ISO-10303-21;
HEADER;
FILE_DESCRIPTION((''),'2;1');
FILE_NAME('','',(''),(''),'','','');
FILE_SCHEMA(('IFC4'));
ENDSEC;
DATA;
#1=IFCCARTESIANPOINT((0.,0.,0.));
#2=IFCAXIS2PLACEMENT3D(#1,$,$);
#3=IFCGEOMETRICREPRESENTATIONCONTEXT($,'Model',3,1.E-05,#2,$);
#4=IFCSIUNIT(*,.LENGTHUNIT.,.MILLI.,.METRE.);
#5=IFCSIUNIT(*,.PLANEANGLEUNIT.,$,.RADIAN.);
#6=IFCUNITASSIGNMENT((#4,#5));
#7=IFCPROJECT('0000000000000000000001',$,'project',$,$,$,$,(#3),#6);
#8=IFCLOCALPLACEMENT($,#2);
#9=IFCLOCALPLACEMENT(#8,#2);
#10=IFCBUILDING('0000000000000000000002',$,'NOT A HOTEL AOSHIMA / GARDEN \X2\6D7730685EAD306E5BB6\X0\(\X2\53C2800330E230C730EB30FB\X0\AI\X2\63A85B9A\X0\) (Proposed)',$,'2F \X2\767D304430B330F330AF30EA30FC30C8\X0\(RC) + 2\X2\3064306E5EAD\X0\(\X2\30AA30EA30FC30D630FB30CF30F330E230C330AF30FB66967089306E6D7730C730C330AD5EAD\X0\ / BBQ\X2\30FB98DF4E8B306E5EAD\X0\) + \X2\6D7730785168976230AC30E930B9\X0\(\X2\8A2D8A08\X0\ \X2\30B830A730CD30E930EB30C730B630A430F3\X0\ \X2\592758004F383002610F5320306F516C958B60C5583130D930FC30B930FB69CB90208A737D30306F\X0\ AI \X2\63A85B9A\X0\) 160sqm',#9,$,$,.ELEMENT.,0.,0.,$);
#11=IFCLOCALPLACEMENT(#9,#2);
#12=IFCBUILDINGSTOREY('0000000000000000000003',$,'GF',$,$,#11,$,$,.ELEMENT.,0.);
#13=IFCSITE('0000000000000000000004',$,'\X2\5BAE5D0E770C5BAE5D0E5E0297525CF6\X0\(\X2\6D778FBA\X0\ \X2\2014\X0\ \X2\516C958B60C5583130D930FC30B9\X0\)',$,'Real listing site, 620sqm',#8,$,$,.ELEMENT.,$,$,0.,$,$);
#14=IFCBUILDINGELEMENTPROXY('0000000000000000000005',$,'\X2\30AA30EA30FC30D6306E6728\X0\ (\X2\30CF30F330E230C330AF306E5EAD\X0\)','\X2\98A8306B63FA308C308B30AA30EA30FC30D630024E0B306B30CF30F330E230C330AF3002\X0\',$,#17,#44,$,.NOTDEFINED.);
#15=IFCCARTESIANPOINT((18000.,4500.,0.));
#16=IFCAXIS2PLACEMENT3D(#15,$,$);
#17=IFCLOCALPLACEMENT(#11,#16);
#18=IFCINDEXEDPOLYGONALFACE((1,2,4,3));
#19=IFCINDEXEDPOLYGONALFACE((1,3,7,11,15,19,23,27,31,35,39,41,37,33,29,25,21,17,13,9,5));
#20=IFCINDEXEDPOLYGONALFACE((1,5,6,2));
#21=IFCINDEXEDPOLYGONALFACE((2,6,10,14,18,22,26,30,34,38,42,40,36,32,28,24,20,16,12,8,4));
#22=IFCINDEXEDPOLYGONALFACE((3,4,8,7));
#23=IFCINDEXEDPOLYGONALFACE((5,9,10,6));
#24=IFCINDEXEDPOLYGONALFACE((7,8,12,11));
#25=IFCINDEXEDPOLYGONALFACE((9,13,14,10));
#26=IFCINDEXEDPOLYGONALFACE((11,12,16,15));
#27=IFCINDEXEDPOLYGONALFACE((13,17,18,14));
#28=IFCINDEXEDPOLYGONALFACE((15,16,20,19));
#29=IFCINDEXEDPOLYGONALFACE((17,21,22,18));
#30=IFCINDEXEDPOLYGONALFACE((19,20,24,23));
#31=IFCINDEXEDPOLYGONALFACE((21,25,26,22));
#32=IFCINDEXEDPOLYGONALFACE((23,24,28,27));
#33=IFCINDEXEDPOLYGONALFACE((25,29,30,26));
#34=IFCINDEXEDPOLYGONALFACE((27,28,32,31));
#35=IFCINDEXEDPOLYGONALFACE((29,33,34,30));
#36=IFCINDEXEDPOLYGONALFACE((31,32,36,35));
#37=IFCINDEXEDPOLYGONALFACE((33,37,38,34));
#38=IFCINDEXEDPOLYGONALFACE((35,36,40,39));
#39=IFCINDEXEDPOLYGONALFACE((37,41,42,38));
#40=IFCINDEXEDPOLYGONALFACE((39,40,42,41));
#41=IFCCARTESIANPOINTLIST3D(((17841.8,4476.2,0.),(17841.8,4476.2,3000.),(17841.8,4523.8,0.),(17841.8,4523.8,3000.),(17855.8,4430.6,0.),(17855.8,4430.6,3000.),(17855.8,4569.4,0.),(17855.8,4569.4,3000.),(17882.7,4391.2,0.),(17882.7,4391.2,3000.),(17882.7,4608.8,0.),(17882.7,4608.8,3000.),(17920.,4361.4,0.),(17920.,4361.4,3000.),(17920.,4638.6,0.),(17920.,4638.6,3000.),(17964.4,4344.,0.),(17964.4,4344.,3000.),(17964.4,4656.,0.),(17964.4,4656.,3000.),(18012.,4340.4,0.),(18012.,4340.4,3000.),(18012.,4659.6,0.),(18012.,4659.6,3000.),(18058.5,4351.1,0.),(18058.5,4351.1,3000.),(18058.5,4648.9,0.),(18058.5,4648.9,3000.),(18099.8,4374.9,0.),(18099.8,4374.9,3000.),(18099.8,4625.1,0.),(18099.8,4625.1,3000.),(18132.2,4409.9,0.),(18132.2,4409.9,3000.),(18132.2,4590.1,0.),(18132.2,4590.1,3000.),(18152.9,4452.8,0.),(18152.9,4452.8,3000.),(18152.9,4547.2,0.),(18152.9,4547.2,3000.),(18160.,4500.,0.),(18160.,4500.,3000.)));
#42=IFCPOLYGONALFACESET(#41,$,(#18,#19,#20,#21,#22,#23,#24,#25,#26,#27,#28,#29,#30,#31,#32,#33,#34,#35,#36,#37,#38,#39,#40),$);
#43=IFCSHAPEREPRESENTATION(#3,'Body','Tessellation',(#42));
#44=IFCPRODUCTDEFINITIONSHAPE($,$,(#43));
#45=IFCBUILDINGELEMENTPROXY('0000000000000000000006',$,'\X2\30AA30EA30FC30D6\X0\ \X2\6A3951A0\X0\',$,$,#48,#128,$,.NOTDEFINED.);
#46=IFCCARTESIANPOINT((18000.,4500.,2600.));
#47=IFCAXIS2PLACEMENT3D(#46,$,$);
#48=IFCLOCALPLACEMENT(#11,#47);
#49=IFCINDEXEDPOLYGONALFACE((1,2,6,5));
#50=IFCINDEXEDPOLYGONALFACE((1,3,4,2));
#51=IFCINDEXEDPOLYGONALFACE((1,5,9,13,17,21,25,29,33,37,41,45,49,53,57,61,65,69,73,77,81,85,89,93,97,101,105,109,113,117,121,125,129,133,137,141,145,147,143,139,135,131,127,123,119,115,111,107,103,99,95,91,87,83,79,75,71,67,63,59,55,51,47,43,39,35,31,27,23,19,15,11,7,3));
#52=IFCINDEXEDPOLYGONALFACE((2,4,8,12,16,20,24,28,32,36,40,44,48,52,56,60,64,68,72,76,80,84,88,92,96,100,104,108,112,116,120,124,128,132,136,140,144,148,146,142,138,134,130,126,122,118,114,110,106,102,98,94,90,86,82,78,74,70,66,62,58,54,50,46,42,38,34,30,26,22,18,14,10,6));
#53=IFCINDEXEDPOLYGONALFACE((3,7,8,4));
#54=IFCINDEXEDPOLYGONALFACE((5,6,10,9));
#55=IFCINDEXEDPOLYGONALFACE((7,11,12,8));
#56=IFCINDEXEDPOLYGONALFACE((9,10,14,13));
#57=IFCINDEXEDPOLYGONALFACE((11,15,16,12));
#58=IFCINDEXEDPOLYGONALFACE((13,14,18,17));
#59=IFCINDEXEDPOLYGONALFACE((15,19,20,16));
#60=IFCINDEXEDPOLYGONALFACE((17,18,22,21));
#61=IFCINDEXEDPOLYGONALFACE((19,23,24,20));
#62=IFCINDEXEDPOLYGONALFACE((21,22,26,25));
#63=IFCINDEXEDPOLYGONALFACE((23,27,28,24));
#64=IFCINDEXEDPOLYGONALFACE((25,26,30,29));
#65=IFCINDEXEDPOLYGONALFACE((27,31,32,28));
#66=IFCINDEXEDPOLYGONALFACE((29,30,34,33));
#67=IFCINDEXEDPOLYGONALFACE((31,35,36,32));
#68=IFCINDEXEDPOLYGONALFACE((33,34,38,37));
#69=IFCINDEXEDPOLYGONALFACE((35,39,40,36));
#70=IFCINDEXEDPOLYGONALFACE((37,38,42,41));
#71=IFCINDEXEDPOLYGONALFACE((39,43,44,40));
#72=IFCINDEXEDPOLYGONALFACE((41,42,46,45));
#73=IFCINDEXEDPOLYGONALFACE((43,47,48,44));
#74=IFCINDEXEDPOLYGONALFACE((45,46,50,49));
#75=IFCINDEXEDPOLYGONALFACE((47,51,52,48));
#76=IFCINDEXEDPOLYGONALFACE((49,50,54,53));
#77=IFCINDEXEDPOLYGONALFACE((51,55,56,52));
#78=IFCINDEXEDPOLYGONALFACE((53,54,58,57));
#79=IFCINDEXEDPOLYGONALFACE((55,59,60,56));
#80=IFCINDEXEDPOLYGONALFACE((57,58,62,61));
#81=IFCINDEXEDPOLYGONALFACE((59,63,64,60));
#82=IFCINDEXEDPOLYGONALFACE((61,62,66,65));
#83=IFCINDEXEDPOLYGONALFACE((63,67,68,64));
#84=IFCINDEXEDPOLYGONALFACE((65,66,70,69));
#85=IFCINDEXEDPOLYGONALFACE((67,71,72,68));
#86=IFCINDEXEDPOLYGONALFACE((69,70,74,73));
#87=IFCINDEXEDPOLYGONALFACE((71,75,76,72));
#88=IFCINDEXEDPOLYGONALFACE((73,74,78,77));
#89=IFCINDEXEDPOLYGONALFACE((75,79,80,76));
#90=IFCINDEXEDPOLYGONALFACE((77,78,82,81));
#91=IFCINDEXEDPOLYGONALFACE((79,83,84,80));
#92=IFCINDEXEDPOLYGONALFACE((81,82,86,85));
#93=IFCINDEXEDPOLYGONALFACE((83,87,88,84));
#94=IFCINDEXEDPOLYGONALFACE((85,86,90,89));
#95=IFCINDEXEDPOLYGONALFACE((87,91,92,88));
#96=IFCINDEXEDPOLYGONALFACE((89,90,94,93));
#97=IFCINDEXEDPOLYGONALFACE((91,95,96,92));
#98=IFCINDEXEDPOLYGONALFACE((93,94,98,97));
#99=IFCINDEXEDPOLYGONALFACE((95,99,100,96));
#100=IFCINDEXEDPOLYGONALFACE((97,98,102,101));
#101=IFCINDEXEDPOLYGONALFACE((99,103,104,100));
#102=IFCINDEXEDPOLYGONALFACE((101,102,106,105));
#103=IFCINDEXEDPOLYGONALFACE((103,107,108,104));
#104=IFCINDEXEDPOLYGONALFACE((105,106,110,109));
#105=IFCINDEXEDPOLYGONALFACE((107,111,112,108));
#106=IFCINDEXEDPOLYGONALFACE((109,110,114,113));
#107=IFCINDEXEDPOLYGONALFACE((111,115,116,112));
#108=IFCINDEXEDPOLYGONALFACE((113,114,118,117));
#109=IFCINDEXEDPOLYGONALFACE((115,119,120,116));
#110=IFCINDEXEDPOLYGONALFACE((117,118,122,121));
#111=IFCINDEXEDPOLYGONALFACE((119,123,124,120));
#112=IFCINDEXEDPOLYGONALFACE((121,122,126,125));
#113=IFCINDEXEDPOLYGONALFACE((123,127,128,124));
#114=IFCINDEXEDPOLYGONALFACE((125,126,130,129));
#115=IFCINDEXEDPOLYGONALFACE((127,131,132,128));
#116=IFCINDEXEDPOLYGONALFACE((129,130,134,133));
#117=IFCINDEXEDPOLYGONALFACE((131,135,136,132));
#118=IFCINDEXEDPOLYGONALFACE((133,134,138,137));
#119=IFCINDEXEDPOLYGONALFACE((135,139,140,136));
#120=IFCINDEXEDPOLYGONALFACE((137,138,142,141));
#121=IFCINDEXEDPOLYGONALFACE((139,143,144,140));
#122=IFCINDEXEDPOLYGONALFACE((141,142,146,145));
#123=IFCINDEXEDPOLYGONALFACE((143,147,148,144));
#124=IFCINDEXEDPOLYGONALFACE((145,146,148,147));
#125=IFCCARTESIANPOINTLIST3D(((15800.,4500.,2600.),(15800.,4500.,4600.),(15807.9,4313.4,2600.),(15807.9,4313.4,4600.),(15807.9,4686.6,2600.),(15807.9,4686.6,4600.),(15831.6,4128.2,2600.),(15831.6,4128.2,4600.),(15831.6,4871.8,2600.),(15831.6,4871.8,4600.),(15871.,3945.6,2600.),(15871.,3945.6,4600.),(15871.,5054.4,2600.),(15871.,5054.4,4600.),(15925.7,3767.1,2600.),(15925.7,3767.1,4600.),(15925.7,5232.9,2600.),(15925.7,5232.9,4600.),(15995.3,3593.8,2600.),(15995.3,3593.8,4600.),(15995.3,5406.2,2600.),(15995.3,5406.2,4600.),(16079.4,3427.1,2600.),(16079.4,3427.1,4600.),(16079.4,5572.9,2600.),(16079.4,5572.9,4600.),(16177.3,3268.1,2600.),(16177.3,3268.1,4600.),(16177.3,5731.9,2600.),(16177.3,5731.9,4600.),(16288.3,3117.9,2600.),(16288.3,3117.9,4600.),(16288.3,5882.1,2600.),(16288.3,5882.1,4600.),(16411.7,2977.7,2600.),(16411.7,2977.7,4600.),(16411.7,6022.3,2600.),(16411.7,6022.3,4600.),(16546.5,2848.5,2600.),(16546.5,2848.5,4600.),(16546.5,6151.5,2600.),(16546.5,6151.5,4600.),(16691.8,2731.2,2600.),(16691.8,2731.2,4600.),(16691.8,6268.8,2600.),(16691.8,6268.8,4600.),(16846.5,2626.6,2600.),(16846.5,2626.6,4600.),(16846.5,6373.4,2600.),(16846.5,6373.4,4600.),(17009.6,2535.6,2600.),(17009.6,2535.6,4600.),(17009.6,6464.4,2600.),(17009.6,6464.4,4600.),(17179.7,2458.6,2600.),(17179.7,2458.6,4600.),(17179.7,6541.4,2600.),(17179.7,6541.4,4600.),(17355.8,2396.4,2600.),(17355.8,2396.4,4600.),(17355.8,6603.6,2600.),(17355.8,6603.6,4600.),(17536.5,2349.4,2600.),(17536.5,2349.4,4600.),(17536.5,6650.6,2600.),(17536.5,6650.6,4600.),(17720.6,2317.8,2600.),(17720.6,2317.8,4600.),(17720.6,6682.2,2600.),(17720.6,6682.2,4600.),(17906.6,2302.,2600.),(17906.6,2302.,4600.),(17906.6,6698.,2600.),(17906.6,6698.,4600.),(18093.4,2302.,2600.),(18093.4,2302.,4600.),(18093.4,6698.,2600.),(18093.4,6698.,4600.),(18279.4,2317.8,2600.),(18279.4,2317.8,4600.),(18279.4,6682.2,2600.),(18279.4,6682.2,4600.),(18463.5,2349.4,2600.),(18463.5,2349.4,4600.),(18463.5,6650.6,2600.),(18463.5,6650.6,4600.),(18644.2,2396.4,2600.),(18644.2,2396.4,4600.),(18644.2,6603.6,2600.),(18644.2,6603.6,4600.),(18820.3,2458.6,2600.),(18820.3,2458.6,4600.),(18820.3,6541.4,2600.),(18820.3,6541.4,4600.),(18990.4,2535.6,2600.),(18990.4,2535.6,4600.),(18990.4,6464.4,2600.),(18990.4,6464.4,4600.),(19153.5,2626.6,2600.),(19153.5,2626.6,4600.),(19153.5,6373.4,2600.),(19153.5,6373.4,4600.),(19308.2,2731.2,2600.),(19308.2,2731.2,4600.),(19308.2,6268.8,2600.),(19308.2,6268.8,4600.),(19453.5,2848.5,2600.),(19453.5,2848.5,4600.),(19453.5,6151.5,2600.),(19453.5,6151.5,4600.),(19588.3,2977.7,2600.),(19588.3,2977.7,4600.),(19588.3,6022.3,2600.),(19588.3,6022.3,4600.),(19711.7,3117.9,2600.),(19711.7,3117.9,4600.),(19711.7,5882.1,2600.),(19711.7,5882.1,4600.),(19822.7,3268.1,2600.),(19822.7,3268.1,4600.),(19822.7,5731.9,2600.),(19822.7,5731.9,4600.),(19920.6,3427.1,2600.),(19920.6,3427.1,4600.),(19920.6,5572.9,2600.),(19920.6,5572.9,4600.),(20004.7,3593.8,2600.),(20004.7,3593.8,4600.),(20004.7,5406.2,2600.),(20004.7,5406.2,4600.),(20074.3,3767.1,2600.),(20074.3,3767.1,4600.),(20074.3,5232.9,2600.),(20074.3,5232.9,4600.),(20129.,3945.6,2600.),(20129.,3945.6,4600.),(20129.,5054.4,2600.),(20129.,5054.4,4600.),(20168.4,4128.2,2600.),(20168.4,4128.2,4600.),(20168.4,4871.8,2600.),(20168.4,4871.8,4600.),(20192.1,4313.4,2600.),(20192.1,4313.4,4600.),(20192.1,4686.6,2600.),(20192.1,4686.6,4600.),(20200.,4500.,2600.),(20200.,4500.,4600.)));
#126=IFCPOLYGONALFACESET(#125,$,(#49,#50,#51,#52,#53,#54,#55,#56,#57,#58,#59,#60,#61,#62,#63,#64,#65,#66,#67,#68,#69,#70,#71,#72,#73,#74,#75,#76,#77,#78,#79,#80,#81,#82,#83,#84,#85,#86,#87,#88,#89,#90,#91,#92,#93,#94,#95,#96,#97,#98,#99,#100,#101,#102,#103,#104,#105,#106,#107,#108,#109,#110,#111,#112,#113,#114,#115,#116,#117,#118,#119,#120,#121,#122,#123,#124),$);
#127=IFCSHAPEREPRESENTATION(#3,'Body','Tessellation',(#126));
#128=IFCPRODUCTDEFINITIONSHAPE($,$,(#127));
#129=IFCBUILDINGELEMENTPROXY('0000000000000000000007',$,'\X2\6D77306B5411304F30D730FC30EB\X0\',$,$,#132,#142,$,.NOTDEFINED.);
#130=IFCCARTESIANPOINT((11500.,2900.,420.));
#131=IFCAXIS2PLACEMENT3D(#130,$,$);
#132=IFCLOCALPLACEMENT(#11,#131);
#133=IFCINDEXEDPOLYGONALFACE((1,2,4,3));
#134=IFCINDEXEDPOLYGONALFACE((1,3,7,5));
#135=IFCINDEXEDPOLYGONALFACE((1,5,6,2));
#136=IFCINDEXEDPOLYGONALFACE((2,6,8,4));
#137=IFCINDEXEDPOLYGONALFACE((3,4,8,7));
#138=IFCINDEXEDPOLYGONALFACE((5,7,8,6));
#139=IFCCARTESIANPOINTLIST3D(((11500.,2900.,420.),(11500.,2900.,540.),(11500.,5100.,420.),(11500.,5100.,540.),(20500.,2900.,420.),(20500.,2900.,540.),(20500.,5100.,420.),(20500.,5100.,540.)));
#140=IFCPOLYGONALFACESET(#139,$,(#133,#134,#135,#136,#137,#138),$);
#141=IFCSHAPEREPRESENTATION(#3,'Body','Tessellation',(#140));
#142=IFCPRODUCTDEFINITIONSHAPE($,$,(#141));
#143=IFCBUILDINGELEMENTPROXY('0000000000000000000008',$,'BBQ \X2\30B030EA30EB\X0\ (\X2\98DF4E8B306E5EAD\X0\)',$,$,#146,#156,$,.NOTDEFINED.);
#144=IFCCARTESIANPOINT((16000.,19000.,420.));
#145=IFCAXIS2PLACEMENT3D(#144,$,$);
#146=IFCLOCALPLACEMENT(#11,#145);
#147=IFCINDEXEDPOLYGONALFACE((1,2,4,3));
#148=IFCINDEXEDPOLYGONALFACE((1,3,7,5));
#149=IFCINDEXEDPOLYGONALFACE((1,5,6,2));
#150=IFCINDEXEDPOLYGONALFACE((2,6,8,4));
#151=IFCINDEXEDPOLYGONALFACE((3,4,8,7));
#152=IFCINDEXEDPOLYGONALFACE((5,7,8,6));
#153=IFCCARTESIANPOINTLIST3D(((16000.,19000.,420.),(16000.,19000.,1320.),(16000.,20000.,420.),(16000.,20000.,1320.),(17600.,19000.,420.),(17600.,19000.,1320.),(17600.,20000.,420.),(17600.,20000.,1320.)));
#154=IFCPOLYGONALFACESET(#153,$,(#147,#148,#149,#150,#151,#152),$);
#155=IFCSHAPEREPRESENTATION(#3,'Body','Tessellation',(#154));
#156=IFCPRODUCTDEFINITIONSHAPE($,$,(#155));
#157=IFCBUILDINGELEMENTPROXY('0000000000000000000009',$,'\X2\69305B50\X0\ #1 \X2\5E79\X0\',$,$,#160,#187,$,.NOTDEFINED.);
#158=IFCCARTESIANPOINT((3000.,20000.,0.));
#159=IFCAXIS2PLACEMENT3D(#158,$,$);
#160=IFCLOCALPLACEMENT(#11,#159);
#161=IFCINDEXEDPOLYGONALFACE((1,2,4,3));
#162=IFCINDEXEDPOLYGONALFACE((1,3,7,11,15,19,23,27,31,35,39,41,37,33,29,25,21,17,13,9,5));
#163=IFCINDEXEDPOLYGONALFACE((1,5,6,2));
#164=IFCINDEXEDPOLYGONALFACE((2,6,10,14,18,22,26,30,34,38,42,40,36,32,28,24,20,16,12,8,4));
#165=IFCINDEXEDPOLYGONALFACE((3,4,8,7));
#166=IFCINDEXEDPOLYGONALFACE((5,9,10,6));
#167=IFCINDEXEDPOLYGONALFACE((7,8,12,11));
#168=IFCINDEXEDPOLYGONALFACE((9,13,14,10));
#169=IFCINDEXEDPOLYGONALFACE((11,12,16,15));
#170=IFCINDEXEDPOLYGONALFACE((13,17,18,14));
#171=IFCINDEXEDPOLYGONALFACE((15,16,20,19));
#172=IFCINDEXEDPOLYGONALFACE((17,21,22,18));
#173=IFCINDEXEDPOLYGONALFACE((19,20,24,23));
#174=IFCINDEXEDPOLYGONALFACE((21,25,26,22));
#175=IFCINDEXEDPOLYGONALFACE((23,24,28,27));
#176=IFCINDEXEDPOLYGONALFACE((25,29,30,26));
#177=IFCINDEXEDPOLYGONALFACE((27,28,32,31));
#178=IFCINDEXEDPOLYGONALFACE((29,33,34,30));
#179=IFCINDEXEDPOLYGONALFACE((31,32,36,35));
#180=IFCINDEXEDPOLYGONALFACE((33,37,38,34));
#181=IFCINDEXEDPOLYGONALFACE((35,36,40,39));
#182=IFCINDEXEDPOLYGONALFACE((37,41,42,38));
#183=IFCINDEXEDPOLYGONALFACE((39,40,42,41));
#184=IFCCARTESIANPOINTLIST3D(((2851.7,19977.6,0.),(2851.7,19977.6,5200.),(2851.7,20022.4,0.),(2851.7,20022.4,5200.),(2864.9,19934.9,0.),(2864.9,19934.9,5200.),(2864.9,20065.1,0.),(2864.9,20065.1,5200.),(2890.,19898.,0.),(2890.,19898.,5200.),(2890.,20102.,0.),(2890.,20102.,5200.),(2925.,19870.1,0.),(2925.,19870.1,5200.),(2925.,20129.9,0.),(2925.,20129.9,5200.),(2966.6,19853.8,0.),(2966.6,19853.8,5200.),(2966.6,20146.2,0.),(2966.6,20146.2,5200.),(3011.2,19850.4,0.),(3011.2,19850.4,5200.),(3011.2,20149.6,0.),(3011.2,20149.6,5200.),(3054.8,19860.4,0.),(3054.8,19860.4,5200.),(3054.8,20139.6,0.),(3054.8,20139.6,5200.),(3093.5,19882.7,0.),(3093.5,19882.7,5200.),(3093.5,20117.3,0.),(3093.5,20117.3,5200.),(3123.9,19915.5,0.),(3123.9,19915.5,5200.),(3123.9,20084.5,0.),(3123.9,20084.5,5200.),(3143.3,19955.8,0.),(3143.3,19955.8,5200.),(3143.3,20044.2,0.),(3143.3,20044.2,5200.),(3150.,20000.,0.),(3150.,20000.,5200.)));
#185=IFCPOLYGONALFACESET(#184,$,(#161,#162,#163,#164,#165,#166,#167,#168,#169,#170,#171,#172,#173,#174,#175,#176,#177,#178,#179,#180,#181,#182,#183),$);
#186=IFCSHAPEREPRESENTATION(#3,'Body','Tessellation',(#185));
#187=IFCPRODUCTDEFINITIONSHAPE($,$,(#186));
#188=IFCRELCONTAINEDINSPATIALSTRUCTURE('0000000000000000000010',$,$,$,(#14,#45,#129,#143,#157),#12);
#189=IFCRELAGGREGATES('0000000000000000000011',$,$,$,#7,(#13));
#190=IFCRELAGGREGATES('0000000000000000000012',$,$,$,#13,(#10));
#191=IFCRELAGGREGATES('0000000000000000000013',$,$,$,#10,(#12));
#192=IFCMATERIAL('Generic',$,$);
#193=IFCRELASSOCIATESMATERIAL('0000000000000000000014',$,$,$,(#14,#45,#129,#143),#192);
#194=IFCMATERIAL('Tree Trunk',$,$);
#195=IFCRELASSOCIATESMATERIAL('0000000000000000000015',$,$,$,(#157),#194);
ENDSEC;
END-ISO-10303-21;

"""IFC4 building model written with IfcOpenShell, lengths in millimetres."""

from ifc_helpers import new_model, si_unit, frame, frame_2d, origin, origin_2d, place, context, project, spatial, rectangle, circle, extrude, material, element, save


model = new_model("IFC4")

# Units and contexts
model_context = context("Model", 3, precision=1e-05, world=origin())
ifc_project = project(units=[si_unit("LENGTHUNIT", "METRE", prefix="MILLI"), si_unit("PLANEANGLEUNIT", "RADIAN")], contexts=[model_context])

# Site, building, storey
site_placement = place(None, origin())
site = spatial("IfcSite", under=ifc_project, at=site_placement, Name="宮崎県宮崎市青島(海辺 — 公開情報ベース)", ObjectType="Real listing site, 620sqm", CompositionType="ELEMENT", RefElevation=0.0)
building_placement = place(site_placement, origin())
building = spatial("IfcBuilding", under=site, at=building_placement, Name="NOT A HOTEL AOSHIMA / GARDEN 海と庭の家(参考モデル・AI推定) (Proposed)", ObjectType="2F 白いコンクリート(RC) + 2つの庭(オリーブ・ハンモック・暖炉の海デッキ庭 / BBQ・食事の庭) + 海へ全面ガラス(設計 ジェネラルデザイン 大堀伸。意匠は公開情報ベース・構造詳細は AI 推定) 160sqm", CompositionType="ELEMENT", ElevationOfRefHeight=0.0, ElevationOfTerrain=0.0)
storey_placement = place(building_placement, origin())
storey = spatial("IfcBuildingStorey", under=building, at=storey_placement, Name="GF", CompositionType="ELEMENT", Elevation=0.0)

# Shared definitions
ifc_material_1 = material(Name="Generic")

# Building element proxies
proxy_1_placement = place(storey_placement, frame((18000.0, 4500.0, 0.0)))
element("IfcBuildingElementProxy", 1, at=proxy_1_placement, inside=storey, material=ifc_material_1, Name="オリーブの木 (ハンモックの庭)", Description="風に揺れるオリーブ。下にハンモック。", PredefinedType="NOTDEFINED", context=model_context, shape_type="SweptSolid", body=[
    extrude(circle(Radius=160.0, at=origin_2d()), frame((18000.0, 4500.0, 0.0)), (0.0, 0.0, 1.0), 3000.0),
])
proxy_2_placement = place(storey_placement, frame((18000.0, 4500.0, 2600.0)))
element("IfcBuildingElementProxy", 2, at=proxy_2_placement, inside=storey, material=ifc_material_1, Name="オリーブ 樹冠", PredefinedType="NOTDEFINED", context=model_context, shape_type="SweptSolid", body=[
    extrude(circle(Radius=2200.0, at=origin_2d()), frame((18000.0, 4500.0, 2600.0)), (0.0, 0.0, 1.0), 2000.0),
])
proxy_3_placement = place(storey_placement, frame((11500.0, 2900.0, 420.0)))
element("IfcBuildingElementProxy", 3, at=proxy_3_placement, inside=storey, material=ifc_material_1, Name="海に向くプール", PredefinedType="NOTDEFINED", context=model_context, shape_type="SweptSolid", body=[
    extrude(rectangle(XDim=9000.0, YDim=2200.0, at=frame_2d((4500.0, 1100.0))), frame((11500.0, 2900.0, 420.0)), (0.0, 0.0, 1.0), 120.0),
])
proxy_4_placement = place(storey_placement, frame((16000.0, 19000.0, 420.0)))
element("IfcBuildingElementProxy", 4, at=proxy_4_placement, inside=storey, material=ifc_material_1, Name="BBQ グリル (食事の庭)", PredefinedType="NOTDEFINED", context=model_context, shape_type="SweptSolid", body=[
    extrude(rectangle(XDim=1600.0, YDim=1000.0, at=frame_2d((800.0, 500.0))), frame((16000.0, 19000.0, 420.0)), (0.0, 0.0, 1.0), 900.0),
])
ifc_material_2 = material(Name="Tree Trunk")
proxy_5_placement = place(storey_placement, frame((3000.0, 20000.0, 0.0)))
element("IfcBuildingElementProxy", 5, at=proxy_5_placement, inside=storey, material=ifc_material_2, Name="椰子 #1 幹", PredefinedType="NOTDEFINED", context=model_context, shape_type="SweptSolid", body=[
    extrude(circle(Radius=150.0, at=origin_2d()), frame((3000.0, 20000.0, 0.0)), (0.0, 0.0, 1.0), 5200.0),
])

save(model, "model.ifc")
